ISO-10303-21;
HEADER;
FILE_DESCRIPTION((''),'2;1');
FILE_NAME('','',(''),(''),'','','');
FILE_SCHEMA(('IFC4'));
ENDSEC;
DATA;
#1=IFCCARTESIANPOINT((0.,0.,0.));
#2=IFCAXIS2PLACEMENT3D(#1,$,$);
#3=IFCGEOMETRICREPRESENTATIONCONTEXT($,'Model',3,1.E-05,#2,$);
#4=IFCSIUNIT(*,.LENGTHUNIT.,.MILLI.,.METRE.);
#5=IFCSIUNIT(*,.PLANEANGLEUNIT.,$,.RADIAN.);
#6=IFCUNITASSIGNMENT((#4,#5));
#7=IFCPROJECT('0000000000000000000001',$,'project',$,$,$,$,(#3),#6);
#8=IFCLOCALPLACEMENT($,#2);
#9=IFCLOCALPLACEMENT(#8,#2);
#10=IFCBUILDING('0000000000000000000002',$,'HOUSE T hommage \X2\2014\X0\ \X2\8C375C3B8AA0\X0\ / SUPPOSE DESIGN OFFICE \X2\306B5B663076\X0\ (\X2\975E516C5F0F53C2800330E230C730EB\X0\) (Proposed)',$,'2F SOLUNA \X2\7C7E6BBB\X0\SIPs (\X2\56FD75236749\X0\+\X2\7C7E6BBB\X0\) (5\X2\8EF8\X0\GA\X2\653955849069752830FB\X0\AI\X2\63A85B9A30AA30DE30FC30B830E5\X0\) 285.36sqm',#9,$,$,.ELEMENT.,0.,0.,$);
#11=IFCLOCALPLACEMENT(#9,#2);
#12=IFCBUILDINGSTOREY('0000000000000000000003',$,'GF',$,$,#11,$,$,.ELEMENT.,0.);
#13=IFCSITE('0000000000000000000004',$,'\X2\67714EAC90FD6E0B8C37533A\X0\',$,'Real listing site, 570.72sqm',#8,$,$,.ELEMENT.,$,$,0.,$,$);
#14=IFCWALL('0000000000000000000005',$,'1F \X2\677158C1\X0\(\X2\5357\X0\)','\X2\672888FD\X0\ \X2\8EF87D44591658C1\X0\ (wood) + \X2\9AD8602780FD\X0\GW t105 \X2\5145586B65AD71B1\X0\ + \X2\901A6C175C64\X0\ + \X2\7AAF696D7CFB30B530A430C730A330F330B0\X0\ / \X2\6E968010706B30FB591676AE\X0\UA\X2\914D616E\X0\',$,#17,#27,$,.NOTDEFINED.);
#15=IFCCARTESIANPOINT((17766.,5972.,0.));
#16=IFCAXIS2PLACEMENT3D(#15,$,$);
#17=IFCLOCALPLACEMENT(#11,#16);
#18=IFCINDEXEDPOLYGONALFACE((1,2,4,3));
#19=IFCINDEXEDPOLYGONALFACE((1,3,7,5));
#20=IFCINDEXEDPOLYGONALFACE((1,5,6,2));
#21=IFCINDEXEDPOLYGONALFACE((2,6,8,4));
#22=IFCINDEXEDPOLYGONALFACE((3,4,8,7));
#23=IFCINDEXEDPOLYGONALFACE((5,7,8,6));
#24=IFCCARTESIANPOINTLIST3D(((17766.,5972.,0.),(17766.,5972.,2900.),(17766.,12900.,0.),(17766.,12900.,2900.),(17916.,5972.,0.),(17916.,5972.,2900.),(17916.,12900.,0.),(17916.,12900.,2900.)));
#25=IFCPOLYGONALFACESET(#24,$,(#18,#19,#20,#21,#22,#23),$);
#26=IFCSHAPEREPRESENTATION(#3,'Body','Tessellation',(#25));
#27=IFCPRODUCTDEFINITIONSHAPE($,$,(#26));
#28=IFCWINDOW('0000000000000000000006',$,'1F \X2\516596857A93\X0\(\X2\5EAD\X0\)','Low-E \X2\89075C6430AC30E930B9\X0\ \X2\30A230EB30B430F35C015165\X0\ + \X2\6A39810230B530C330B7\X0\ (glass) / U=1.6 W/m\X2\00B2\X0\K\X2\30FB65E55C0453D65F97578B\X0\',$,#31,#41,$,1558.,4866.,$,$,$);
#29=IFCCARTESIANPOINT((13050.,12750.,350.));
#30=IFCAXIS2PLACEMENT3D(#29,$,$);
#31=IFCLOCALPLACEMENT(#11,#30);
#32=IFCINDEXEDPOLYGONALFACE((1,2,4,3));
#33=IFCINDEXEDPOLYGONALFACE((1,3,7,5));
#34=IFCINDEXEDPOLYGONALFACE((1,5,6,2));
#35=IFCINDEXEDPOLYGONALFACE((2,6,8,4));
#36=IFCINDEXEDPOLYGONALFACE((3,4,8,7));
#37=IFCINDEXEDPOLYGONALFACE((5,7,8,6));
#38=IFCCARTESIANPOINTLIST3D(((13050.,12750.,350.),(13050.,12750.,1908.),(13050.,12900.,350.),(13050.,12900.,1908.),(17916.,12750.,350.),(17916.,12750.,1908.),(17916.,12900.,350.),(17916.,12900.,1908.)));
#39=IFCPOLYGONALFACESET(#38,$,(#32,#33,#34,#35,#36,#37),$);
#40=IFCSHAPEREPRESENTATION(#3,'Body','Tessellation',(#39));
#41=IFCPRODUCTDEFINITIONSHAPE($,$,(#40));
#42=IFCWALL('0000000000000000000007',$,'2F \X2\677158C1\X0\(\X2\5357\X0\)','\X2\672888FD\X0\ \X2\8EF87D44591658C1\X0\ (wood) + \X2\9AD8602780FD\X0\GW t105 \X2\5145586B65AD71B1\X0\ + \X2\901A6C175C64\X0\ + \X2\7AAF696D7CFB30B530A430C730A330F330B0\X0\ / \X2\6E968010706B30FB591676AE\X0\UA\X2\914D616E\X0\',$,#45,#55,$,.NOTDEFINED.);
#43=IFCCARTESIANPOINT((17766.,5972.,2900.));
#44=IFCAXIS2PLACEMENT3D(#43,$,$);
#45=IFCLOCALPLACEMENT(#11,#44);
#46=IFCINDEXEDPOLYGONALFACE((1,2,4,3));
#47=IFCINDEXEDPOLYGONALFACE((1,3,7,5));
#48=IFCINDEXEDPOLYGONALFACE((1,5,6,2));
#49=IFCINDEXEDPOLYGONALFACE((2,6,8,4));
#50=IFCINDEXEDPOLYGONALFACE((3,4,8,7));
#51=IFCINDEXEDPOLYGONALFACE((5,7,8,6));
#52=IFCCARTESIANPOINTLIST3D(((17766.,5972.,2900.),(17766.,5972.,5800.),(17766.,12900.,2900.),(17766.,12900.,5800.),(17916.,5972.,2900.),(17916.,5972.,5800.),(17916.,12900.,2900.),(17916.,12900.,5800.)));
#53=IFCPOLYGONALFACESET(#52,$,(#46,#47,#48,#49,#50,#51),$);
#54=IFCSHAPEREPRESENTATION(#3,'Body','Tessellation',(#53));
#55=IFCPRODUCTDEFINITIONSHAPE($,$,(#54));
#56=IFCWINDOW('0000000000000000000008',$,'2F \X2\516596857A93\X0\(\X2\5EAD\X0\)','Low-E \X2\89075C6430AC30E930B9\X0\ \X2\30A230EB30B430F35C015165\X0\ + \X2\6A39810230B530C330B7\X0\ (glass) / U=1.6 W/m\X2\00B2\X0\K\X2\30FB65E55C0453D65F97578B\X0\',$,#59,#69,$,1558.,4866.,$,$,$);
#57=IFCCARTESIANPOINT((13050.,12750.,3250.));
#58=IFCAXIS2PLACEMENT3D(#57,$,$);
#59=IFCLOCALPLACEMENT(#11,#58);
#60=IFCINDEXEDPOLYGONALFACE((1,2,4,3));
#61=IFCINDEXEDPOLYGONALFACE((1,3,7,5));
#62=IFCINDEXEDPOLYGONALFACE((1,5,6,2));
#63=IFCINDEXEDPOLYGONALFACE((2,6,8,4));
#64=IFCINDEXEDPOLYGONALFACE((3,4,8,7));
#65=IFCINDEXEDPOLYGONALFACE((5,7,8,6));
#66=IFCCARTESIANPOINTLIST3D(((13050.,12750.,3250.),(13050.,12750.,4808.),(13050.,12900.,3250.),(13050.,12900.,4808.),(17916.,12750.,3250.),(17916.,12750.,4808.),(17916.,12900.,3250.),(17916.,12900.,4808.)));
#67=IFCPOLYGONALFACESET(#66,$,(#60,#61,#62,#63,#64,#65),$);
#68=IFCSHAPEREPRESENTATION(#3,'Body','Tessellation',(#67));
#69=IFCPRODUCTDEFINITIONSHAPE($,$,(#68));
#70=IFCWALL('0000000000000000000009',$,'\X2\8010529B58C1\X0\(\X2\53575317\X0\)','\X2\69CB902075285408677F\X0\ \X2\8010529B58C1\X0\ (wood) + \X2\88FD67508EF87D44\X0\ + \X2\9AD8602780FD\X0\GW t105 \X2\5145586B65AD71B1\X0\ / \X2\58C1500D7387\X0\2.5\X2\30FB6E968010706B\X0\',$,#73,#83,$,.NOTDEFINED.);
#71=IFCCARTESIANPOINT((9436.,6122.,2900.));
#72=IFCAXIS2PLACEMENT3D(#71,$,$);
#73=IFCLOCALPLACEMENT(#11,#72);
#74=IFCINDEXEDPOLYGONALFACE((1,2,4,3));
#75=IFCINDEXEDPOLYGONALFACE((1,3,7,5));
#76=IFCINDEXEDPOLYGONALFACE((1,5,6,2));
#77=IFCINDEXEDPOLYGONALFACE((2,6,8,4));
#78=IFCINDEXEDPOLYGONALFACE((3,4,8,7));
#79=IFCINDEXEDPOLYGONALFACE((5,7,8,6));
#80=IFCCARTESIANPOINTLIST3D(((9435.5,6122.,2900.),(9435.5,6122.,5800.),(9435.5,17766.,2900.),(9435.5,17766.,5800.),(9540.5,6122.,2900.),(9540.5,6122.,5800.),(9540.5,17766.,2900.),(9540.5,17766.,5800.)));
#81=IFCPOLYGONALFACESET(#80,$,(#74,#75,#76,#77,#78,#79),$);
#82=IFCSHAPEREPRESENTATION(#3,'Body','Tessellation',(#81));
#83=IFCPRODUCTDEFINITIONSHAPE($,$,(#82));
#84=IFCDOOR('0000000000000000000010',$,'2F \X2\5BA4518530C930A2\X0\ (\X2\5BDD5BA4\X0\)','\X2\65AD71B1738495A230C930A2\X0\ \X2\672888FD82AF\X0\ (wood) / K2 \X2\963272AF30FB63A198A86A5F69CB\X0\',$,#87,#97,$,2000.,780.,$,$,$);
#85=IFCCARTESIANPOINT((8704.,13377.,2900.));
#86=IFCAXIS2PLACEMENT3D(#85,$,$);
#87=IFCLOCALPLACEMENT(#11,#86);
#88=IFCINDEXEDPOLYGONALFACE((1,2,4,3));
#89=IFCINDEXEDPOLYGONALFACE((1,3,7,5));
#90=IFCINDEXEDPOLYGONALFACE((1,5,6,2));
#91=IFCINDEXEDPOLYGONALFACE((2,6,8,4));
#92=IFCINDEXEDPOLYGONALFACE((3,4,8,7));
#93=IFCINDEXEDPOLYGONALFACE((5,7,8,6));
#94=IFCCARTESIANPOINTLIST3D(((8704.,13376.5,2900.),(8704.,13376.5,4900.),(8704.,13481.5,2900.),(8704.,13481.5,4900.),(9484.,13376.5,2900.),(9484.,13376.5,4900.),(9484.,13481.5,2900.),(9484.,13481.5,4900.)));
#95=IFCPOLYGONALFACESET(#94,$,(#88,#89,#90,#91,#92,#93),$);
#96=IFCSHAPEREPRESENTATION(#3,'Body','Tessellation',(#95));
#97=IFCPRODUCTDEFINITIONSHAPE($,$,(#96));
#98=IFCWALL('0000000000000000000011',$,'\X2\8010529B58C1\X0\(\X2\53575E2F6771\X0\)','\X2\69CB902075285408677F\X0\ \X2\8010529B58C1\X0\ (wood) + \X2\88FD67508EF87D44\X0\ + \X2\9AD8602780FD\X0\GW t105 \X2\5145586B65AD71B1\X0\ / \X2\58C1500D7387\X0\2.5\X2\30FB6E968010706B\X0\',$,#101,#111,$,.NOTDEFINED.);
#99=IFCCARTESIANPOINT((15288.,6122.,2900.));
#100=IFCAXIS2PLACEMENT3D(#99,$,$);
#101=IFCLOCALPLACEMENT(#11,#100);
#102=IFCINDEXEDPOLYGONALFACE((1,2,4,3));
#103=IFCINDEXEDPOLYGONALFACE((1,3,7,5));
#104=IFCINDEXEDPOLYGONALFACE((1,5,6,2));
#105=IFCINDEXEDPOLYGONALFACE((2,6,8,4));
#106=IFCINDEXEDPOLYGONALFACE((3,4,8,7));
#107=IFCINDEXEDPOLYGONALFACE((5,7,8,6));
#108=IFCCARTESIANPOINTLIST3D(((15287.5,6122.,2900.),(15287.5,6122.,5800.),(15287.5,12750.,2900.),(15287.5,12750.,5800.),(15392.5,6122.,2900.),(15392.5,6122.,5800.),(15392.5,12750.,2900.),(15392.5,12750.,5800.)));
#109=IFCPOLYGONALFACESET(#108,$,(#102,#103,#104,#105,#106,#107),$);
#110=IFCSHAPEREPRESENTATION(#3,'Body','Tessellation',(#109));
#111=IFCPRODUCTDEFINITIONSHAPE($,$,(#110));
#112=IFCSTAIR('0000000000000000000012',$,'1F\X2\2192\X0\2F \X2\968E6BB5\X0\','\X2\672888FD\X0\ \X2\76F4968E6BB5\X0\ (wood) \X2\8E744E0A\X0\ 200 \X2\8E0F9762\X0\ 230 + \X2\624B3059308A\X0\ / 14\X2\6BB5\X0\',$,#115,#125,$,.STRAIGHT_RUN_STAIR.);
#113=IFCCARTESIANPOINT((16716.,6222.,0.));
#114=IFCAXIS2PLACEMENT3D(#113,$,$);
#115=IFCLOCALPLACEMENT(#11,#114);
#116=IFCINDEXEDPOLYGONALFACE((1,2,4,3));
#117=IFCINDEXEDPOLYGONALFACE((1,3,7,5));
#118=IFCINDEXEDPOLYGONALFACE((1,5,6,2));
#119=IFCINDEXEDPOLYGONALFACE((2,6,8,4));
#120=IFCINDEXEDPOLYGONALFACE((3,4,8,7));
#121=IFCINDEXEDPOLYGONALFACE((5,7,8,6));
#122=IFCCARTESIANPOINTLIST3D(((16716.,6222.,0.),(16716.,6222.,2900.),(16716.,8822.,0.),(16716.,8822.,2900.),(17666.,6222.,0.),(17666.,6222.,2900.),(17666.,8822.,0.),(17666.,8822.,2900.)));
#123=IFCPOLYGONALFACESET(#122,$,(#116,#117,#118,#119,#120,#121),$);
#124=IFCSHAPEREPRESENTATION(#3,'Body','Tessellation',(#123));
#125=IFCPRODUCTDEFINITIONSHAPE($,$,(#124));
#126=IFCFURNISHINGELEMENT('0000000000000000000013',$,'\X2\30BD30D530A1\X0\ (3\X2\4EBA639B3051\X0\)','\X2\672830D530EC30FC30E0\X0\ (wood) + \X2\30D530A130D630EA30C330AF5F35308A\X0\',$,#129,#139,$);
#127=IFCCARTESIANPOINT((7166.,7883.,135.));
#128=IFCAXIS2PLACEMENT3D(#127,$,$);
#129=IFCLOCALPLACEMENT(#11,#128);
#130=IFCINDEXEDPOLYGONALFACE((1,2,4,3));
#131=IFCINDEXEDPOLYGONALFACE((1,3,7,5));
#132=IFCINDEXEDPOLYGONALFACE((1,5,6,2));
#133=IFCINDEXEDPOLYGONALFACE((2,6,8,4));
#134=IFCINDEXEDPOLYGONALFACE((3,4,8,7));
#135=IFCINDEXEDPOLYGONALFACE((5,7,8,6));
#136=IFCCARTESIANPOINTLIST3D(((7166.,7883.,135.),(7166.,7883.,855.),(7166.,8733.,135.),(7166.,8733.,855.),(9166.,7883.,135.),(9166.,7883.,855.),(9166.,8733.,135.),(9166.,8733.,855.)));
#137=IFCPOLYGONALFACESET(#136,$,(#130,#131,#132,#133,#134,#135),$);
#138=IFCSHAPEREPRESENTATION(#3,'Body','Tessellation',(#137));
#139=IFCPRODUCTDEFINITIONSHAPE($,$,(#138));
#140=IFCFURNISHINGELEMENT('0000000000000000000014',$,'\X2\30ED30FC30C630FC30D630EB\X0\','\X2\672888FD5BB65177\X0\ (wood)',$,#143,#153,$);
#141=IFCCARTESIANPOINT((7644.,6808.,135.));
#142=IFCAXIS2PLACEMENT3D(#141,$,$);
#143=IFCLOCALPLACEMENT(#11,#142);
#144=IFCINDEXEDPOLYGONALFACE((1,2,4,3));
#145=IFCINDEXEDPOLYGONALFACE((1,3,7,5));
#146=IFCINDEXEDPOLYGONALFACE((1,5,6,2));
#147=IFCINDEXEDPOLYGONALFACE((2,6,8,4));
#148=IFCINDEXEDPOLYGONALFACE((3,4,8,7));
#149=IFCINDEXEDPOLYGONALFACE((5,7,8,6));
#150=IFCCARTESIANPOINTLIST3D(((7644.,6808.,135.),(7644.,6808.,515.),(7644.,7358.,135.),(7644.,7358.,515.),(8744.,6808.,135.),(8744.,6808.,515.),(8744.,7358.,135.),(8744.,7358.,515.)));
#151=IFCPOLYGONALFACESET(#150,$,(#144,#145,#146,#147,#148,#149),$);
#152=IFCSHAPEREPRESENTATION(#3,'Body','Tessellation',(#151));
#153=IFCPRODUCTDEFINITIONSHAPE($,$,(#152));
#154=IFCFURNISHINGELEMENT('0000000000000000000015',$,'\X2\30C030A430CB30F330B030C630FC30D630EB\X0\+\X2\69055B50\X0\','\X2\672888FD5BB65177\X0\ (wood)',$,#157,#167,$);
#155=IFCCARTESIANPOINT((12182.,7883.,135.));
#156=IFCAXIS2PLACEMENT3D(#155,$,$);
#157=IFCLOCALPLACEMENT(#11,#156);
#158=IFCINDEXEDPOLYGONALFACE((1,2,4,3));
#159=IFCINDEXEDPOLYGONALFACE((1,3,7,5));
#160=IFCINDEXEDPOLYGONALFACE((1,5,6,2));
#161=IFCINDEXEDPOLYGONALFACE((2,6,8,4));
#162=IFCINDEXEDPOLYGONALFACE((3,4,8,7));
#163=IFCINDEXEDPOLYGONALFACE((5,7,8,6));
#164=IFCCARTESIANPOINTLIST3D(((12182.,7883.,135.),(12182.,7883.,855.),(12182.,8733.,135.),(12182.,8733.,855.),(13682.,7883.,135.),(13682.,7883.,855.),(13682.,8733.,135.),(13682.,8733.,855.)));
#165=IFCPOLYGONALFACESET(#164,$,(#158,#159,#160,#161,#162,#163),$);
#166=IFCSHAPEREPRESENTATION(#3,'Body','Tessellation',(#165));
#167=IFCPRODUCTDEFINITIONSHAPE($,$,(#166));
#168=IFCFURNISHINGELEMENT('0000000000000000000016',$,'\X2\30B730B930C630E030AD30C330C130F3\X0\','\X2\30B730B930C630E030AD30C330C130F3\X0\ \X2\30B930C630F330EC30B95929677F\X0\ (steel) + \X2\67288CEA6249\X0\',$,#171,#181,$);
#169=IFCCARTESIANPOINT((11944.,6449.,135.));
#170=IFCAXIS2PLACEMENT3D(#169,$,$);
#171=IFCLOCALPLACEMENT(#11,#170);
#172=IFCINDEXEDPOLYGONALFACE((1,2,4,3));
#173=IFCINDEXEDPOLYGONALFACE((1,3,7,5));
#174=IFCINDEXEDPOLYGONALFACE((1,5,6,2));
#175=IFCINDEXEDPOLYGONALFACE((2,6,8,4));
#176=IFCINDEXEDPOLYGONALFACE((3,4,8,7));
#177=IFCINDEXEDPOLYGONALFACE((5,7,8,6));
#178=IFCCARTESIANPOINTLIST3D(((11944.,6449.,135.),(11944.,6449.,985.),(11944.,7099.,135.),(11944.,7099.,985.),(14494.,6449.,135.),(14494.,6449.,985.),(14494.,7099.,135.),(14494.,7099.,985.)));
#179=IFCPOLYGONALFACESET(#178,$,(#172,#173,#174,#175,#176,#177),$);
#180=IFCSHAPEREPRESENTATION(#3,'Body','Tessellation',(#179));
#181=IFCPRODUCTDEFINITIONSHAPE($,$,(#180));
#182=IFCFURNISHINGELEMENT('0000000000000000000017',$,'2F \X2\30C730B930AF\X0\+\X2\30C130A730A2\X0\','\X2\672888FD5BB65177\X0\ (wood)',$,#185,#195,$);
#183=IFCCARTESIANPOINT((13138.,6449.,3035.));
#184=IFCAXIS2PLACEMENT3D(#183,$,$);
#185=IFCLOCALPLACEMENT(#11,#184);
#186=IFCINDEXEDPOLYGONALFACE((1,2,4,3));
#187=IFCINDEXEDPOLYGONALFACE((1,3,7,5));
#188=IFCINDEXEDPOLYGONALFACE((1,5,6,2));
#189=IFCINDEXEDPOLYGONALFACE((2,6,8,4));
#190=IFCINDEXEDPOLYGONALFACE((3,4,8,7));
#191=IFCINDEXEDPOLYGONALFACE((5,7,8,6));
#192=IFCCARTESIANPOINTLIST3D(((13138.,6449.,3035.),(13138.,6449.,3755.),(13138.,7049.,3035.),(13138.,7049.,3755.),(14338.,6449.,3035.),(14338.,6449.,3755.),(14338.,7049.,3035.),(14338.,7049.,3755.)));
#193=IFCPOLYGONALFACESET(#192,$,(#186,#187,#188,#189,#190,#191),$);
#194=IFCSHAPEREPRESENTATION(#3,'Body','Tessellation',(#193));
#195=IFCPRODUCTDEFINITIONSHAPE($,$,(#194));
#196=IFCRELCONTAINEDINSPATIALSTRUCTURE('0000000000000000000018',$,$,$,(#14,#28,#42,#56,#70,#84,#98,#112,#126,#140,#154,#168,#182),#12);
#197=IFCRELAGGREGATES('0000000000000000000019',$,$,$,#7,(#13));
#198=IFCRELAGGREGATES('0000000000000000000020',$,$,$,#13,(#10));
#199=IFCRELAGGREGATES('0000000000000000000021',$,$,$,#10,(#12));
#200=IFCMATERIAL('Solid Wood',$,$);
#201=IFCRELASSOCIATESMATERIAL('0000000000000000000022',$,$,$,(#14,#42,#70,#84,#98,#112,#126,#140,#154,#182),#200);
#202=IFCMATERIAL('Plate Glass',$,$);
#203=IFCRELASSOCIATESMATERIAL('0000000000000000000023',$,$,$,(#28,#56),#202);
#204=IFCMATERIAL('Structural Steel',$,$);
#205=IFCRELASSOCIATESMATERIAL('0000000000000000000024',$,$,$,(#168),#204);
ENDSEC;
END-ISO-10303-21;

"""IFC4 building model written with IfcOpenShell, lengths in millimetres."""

from ifc_helpers import new_model, si_unit, frame, frame_2d, origin, place, context, project, spatial, rectangle, extrude, material, element, fill, save


model = new_model("IFC4")

# Units and contexts
model_context = context("Model", 3, precision=1e-05, world=origin())
ifc_project = project(units=[si_unit("LENGTHUNIT", "METRE", prefix="MILLI"), si_unit("PLANEANGLEUNIT", "RADIAN")], contexts=[model_context])

# Site, building, storey
site_placement = place(None, origin())
site = spatial("IfcSite", under=ifc_project, at=site_placement, Name="東京都渋谷区", ObjectType="Real listing site, 570.72sqm", CompositionType="ELEMENT", RefElevation=0.0)
building_placement = place(site_placement, origin())
building = spatial("IfcBuilding", under=site, at=building_placement, Name="HOUSE T hommage — 谷尻誠 / SUPPOSE DESIGN OFFICE に学ぶ (非公式参考モデル) (Proposed)", ObjectType="2F SOLUNA 籾殻SIPs (国産杉+籾殻) (5軸GA改善適用・AI推定オマージュ) 285.36sqm", CompositionType="ELEMENT", ElevationOfRefHeight=0.0, ElevationOfTerrain=0.0)
storey_placement = place(building_placement, origin())
storey = spatial("IfcBuildingStorey", under=building, at=storey_placement, Name="GF", CompositionType="ELEMENT", Elevation=0.0)

# Wall, opening, window
ifc_material_1 = material(Name="Solid Wood")
wall_1_placement = place(storey_placement, frame((17766.0, 5972.0, 0.0)))
wall_1 = element("IfcWall", 1, at=wall_1_placement, inside=storey, material=ifc_material_1, Name="1F 東壁(南)", Description="木製 軸組外壁 (wood) + 高性能GW t105 充填断熱 + 通気層 + 窯業系サイディング / 準耐火・外皮UA配慮", PredefinedType="NOTDEFINED", context=model_context, shape_type="SweptSolid", body=[
    extrude(rectangle(XDim=150.0, YDim=6928.0, at=frame_2d((75.0, 3464.0))), frame((17766.0, 5972.0, 0.0)), (0.0, 0.0, 1.0), 2900.0),
])
opening_1_placement = place(storey_placement, frame((13050.0, 12750.0, 350.0)))
opening_1 = element("IfcOpeningElement", 2, at=opening_1_placement, cuts=wall_1, PredefinedType="NOTDEFINED", context=model_context, shape_type="SweptSolid", body=[
    extrude(rectangle(XDim=4866.0, YDim=150.0, at=frame_2d((2433.0, 75.0))), frame((13050.0, 12750.0, 350.0)), (0.0, 0.0, 1.0), 1558.0),
])
ifc_material_2 = material(Name="Plate Glass")
window_1_placement = place(storey_placement, frame((13050.0, 12750.0, 350.0)))
window_1 = element("IfcWindow", 3, at=window_1_placement, inside=storey, material=ifc_material_2, Name="1F 入隅窓(庭)", Description="Low-E 複層ガラス アルゴン封入 + 樹脂サッシ (glass) / U=1.6 W/m²K・日射取得型", OverallHeight=1558.0, OverallWidth=4866.0, context=model_context, shape_type="SweptSolid", body=[
    extrude(rectangle(XDim=4866.0, YDim=150.0, at=frame_2d((2433.0, 75.0))), frame((13050.0, 12750.0, 350.0)), (0.0, 0.0, 1.0), 1558.0),
])
fill(opening_1, window_1)

# Wall, opening, window
wall_2_placement = place(storey_placement, frame((17766.0, 5972.0, 2900.0)))
wall_2 = element("IfcWall", 4, at=wall_2_placement, inside=storey, material=ifc_material_1, Name="2F 東壁(南)", Description="木製 軸組外壁 (wood) + 高性能GW t105 充填断熱 + 通気層 + 窯業系サイディング / 準耐火・外皮UA配慮", PredefinedType="NOTDEFINED", context=model_context, shape_type="SweptSolid", body=[
    extrude(rectangle(XDim=150.0, YDim=6928.0, at=frame_2d((75.0, 3464.0))), frame((17766.0, 5972.0, 2900.0)), (0.0, 0.0, 1.0), 2900.0),
])
opening_2_placement = place(storey_placement, frame((13050.0, 12750.0, 3250.0)))
opening_2 = element("IfcOpeningElement", 5, at=opening_2_placement, cuts=wall_2, PredefinedType="NOTDEFINED", context=model_context, shape_type="SweptSolid", body=[
    extrude(rectangle(XDim=4866.0, YDim=150.0, at=frame_2d((2433.0, 75.0))), frame((13050.0, 12750.0, 3250.0)), (0.0, 0.0, 1.0), 1558.0),
])
window_2_placement = place(storey_placement, frame((13050.0, 12750.0, 3250.0)))
window_2 = element("IfcWindow", 6, at=window_2_placement, inside=storey, material=ifc_material_2, Name="2F 入隅窓(庭)", Description="Low-E 複層ガラス アルゴン封入 + 樹脂サッシ (glass) / U=1.6 W/m²K・日射取得型", OverallHeight=1558.0, OverallWidth=4866.0, context=model_context, shape_type="SweptSolid", body=[
    extrude(rectangle(XDim=4866.0, YDim=150.0, at=frame_2d((2433.0, 75.0))), frame((13050.0, 12750.0, 3250.0)), (0.0, 0.0, 1.0), 1558.0),
])
fill(opening_2, window_2)

# Wall, opening, door
wall_3_placement = place(storey_placement, frame((9436.0, 6122.0, 2900.0)))
wall_3 = element("IfcWall", 7, at=wall_3_placement, inside=storey, material=ifc_material_1, Name="耐力壁(南北)", Description="構造用合板 耐力壁 (wood) + 製材軸組 + 高性能GW t105 充填断熱 / 壁倍率2.5・準耐火", PredefinedType="NOTDEFINED", context=model_context, shape_type="SweptSolid", body=[
    extrude(rectangle(XDim=105.0, YDim=11644.0, at=frame_2d((52.0, 5822.0))), frame((9436.0, 6122.0, 2900.0)), (0.0, 0.0, 1.0), 2900.0),
])
opening_3_placement = place(storey_placement, frame((8704.0, 13377.0, 2900.0)))
opening_3 = element("IfcOpeningElement", 8, at=opening_3_placement, cuts=wall_3, PredefinedType="NOTDEFINED", context=model_context, shape_type="SweptSolid", body=[
    extrude(rectangle(XDim=780.0, YDim=105.0, at=frame_2d((390.0, 52.0))), frame((8704.0, 13377.0, 2900.0)), (0.0, 0.0, 1.0), 2000.0),
])
door_1_placement = place(storey_placement, frame((8704.0, 13377.0, 2900.0)))
door_1 = element("IfcDoor", 9, at=door_1_placement, inside=storey, material=ifc_material_1, Name="2F 室内ドア (寝室)", Description="断熱玄関ドア 木製芯 (wood) / K2 防犯・採風機構", OverallHeight=2000.0, OverallWidth=780.0, context=model_context, shape_type="SweptSolid", body=[
    extrude(rectangle(XDim=780.0, YDim=105.0, at=frame_2d((390.0, 52.0))), frame((8704.0, 13377.0, 2900.0)), (0.0, 0.0, 1.0), 2000.0),
])
fill(opening_3, door_1)

# Wall
wall_4_placement = place(storey_placement, frame((15288.0, 6122.0, 2900.0)))
element("IfcWall", 10, at=wall_4_placement, inside=storey, material=ifc_material_1, Name="耐力壁(南帯東)", Description="構造用合板 耐力壁 (wood) + 製材軸組 + 高性能GW t105 充填断熱 / 壁倍率2.5・準耐火", PredefinedType="NOTDEFINED", context=model_context, shape_type="SweptSolid", body=[
    extrude(rectangle(XDim=105.0, YDim=6628.0, at=frame_2d((52.0, 3314.0))), frame((15288.0, 6122.0, 2900.0)), (0.0, 0.0, 1.0), 2900.0),
])

# Stair
stair_placement = place(storey_placement, frame((16716.0, 6222.0, 0.0)))
element("IfcStair", 11, at=stair_placement, inside=storey, material=ifc_material_1, Name="1F→2F 階段", Description="木製 直階段 (wood) 蹴上 200 踏面 230 + 手すり / 14段", PredefinedType="STRAIGHT_RUN_STAIR", context=model_context, shape_type="SweptSolid", body=[
    extrude(rectangle(XDim=950.0, YDim=2600.0, at=frame_2d((475.0, 1300.0))), frame((16716.0, 6222.0, 0.0)), (0.0, 0.0, 1.0), 2900.0),
])

# Furnishing elements
furnishing_1_placement = place(storey_placement, frame((7166.0, 7883.0, 135.0)))
element("IfcFurnishingElement", 12, at=furnishing_1_placement, inside=storey, material=ifc_material_1, Name="ソファ (3人掛け)", Description="木フレーム (wood) + ファブリック張り", context=model_context, shape_type="SweptSolid", body=[
    extrude(rectangle(XDim=2000.0, YDim=850.0, at=frame_2d((1000.0, 425.0))), frame((7166.0, 7883.0, 135.0)), (0.0, 0.0, 1.0), 720.0),
])
furnishing_2_placement = place(storey_placement, frame((7644.0, 6808.0, 135.0)))
element("IfcFurnishingElement", 13, at=furnishing_2_placement, inside=storey, material=ifc_material_1, Name="ローテーブル", Description="木製家具 (wood)", context=model_context, shape_type="SweptSolid", body=[
    extrude(rectangle(XDim=1100.0, YDim=550.0, at=frame_2d((550.0, 275.0))), frame((7644.0, 6808.0, 135.0)), (0.0, 0.0, 1.0), 380.0),
])
furnishing_3_placement = place(storey_placement, frame((12182.0, 7883.0, 135.0)))
element("IfcFurnishingElement", 14, at=furnishing_3_placement, inside=storey, material=ifc_material_1, Name="ダイニングテーブル+椅子", Description="木製家具 (wood)", context=model_context, shape_type="SweptSolid", body=[
    extrude(rectangle(XDim=1500.0, YDim=850.0, at=frame_2d((750.0, 425.0))), frame((12182.0, 7883.0, 135.0)), (0.0, 0.0, 1.0), 720.0),
])
ifc_material_3 = material(Name="Structural Steel")
furnishing_4_placement = place(storey_placement, frame((11944.0, 6449.0, 135.0)))
element("IfcFurnishingElement", 15, at=furnishing_4_placement, inside=storey, material=ifc_material_3, Name="システムキッチン", Description="システムキッチン ステンレス天板 (steel) + 木質扉", context=model_context, shape_type="SweptSolid", body=[
    extrude(rectangle(XDim=2550.0, YDim=650.0, at=frame_2d((1275.0, 325.0))), frame((11944.0, 6449.0, 135.0)), (0.0, 0.0, 1.0), 850.0),
])
furnishing_5_placement = place(storey_placement, frame((13138.0, 6449.0, 3035.0)))
element("IfcFurnishingElement", 16, at=furnishing_5_placement, inside=storey, material=ifc_material_1, Name="2F デスク+チェア", Description="木製家具 (wood)", context=model_context, shape_type="SweptSolid", body=[
    extrude(rectangle(XDim=1200.0, YDim=600.0, at=frame_2d((600.0, 300.0))), frame((13138.0, 6449.0, 3035.0)), (0.0, 0.0, 1.0), 720.0),
])

save(model, "model.ifc")
